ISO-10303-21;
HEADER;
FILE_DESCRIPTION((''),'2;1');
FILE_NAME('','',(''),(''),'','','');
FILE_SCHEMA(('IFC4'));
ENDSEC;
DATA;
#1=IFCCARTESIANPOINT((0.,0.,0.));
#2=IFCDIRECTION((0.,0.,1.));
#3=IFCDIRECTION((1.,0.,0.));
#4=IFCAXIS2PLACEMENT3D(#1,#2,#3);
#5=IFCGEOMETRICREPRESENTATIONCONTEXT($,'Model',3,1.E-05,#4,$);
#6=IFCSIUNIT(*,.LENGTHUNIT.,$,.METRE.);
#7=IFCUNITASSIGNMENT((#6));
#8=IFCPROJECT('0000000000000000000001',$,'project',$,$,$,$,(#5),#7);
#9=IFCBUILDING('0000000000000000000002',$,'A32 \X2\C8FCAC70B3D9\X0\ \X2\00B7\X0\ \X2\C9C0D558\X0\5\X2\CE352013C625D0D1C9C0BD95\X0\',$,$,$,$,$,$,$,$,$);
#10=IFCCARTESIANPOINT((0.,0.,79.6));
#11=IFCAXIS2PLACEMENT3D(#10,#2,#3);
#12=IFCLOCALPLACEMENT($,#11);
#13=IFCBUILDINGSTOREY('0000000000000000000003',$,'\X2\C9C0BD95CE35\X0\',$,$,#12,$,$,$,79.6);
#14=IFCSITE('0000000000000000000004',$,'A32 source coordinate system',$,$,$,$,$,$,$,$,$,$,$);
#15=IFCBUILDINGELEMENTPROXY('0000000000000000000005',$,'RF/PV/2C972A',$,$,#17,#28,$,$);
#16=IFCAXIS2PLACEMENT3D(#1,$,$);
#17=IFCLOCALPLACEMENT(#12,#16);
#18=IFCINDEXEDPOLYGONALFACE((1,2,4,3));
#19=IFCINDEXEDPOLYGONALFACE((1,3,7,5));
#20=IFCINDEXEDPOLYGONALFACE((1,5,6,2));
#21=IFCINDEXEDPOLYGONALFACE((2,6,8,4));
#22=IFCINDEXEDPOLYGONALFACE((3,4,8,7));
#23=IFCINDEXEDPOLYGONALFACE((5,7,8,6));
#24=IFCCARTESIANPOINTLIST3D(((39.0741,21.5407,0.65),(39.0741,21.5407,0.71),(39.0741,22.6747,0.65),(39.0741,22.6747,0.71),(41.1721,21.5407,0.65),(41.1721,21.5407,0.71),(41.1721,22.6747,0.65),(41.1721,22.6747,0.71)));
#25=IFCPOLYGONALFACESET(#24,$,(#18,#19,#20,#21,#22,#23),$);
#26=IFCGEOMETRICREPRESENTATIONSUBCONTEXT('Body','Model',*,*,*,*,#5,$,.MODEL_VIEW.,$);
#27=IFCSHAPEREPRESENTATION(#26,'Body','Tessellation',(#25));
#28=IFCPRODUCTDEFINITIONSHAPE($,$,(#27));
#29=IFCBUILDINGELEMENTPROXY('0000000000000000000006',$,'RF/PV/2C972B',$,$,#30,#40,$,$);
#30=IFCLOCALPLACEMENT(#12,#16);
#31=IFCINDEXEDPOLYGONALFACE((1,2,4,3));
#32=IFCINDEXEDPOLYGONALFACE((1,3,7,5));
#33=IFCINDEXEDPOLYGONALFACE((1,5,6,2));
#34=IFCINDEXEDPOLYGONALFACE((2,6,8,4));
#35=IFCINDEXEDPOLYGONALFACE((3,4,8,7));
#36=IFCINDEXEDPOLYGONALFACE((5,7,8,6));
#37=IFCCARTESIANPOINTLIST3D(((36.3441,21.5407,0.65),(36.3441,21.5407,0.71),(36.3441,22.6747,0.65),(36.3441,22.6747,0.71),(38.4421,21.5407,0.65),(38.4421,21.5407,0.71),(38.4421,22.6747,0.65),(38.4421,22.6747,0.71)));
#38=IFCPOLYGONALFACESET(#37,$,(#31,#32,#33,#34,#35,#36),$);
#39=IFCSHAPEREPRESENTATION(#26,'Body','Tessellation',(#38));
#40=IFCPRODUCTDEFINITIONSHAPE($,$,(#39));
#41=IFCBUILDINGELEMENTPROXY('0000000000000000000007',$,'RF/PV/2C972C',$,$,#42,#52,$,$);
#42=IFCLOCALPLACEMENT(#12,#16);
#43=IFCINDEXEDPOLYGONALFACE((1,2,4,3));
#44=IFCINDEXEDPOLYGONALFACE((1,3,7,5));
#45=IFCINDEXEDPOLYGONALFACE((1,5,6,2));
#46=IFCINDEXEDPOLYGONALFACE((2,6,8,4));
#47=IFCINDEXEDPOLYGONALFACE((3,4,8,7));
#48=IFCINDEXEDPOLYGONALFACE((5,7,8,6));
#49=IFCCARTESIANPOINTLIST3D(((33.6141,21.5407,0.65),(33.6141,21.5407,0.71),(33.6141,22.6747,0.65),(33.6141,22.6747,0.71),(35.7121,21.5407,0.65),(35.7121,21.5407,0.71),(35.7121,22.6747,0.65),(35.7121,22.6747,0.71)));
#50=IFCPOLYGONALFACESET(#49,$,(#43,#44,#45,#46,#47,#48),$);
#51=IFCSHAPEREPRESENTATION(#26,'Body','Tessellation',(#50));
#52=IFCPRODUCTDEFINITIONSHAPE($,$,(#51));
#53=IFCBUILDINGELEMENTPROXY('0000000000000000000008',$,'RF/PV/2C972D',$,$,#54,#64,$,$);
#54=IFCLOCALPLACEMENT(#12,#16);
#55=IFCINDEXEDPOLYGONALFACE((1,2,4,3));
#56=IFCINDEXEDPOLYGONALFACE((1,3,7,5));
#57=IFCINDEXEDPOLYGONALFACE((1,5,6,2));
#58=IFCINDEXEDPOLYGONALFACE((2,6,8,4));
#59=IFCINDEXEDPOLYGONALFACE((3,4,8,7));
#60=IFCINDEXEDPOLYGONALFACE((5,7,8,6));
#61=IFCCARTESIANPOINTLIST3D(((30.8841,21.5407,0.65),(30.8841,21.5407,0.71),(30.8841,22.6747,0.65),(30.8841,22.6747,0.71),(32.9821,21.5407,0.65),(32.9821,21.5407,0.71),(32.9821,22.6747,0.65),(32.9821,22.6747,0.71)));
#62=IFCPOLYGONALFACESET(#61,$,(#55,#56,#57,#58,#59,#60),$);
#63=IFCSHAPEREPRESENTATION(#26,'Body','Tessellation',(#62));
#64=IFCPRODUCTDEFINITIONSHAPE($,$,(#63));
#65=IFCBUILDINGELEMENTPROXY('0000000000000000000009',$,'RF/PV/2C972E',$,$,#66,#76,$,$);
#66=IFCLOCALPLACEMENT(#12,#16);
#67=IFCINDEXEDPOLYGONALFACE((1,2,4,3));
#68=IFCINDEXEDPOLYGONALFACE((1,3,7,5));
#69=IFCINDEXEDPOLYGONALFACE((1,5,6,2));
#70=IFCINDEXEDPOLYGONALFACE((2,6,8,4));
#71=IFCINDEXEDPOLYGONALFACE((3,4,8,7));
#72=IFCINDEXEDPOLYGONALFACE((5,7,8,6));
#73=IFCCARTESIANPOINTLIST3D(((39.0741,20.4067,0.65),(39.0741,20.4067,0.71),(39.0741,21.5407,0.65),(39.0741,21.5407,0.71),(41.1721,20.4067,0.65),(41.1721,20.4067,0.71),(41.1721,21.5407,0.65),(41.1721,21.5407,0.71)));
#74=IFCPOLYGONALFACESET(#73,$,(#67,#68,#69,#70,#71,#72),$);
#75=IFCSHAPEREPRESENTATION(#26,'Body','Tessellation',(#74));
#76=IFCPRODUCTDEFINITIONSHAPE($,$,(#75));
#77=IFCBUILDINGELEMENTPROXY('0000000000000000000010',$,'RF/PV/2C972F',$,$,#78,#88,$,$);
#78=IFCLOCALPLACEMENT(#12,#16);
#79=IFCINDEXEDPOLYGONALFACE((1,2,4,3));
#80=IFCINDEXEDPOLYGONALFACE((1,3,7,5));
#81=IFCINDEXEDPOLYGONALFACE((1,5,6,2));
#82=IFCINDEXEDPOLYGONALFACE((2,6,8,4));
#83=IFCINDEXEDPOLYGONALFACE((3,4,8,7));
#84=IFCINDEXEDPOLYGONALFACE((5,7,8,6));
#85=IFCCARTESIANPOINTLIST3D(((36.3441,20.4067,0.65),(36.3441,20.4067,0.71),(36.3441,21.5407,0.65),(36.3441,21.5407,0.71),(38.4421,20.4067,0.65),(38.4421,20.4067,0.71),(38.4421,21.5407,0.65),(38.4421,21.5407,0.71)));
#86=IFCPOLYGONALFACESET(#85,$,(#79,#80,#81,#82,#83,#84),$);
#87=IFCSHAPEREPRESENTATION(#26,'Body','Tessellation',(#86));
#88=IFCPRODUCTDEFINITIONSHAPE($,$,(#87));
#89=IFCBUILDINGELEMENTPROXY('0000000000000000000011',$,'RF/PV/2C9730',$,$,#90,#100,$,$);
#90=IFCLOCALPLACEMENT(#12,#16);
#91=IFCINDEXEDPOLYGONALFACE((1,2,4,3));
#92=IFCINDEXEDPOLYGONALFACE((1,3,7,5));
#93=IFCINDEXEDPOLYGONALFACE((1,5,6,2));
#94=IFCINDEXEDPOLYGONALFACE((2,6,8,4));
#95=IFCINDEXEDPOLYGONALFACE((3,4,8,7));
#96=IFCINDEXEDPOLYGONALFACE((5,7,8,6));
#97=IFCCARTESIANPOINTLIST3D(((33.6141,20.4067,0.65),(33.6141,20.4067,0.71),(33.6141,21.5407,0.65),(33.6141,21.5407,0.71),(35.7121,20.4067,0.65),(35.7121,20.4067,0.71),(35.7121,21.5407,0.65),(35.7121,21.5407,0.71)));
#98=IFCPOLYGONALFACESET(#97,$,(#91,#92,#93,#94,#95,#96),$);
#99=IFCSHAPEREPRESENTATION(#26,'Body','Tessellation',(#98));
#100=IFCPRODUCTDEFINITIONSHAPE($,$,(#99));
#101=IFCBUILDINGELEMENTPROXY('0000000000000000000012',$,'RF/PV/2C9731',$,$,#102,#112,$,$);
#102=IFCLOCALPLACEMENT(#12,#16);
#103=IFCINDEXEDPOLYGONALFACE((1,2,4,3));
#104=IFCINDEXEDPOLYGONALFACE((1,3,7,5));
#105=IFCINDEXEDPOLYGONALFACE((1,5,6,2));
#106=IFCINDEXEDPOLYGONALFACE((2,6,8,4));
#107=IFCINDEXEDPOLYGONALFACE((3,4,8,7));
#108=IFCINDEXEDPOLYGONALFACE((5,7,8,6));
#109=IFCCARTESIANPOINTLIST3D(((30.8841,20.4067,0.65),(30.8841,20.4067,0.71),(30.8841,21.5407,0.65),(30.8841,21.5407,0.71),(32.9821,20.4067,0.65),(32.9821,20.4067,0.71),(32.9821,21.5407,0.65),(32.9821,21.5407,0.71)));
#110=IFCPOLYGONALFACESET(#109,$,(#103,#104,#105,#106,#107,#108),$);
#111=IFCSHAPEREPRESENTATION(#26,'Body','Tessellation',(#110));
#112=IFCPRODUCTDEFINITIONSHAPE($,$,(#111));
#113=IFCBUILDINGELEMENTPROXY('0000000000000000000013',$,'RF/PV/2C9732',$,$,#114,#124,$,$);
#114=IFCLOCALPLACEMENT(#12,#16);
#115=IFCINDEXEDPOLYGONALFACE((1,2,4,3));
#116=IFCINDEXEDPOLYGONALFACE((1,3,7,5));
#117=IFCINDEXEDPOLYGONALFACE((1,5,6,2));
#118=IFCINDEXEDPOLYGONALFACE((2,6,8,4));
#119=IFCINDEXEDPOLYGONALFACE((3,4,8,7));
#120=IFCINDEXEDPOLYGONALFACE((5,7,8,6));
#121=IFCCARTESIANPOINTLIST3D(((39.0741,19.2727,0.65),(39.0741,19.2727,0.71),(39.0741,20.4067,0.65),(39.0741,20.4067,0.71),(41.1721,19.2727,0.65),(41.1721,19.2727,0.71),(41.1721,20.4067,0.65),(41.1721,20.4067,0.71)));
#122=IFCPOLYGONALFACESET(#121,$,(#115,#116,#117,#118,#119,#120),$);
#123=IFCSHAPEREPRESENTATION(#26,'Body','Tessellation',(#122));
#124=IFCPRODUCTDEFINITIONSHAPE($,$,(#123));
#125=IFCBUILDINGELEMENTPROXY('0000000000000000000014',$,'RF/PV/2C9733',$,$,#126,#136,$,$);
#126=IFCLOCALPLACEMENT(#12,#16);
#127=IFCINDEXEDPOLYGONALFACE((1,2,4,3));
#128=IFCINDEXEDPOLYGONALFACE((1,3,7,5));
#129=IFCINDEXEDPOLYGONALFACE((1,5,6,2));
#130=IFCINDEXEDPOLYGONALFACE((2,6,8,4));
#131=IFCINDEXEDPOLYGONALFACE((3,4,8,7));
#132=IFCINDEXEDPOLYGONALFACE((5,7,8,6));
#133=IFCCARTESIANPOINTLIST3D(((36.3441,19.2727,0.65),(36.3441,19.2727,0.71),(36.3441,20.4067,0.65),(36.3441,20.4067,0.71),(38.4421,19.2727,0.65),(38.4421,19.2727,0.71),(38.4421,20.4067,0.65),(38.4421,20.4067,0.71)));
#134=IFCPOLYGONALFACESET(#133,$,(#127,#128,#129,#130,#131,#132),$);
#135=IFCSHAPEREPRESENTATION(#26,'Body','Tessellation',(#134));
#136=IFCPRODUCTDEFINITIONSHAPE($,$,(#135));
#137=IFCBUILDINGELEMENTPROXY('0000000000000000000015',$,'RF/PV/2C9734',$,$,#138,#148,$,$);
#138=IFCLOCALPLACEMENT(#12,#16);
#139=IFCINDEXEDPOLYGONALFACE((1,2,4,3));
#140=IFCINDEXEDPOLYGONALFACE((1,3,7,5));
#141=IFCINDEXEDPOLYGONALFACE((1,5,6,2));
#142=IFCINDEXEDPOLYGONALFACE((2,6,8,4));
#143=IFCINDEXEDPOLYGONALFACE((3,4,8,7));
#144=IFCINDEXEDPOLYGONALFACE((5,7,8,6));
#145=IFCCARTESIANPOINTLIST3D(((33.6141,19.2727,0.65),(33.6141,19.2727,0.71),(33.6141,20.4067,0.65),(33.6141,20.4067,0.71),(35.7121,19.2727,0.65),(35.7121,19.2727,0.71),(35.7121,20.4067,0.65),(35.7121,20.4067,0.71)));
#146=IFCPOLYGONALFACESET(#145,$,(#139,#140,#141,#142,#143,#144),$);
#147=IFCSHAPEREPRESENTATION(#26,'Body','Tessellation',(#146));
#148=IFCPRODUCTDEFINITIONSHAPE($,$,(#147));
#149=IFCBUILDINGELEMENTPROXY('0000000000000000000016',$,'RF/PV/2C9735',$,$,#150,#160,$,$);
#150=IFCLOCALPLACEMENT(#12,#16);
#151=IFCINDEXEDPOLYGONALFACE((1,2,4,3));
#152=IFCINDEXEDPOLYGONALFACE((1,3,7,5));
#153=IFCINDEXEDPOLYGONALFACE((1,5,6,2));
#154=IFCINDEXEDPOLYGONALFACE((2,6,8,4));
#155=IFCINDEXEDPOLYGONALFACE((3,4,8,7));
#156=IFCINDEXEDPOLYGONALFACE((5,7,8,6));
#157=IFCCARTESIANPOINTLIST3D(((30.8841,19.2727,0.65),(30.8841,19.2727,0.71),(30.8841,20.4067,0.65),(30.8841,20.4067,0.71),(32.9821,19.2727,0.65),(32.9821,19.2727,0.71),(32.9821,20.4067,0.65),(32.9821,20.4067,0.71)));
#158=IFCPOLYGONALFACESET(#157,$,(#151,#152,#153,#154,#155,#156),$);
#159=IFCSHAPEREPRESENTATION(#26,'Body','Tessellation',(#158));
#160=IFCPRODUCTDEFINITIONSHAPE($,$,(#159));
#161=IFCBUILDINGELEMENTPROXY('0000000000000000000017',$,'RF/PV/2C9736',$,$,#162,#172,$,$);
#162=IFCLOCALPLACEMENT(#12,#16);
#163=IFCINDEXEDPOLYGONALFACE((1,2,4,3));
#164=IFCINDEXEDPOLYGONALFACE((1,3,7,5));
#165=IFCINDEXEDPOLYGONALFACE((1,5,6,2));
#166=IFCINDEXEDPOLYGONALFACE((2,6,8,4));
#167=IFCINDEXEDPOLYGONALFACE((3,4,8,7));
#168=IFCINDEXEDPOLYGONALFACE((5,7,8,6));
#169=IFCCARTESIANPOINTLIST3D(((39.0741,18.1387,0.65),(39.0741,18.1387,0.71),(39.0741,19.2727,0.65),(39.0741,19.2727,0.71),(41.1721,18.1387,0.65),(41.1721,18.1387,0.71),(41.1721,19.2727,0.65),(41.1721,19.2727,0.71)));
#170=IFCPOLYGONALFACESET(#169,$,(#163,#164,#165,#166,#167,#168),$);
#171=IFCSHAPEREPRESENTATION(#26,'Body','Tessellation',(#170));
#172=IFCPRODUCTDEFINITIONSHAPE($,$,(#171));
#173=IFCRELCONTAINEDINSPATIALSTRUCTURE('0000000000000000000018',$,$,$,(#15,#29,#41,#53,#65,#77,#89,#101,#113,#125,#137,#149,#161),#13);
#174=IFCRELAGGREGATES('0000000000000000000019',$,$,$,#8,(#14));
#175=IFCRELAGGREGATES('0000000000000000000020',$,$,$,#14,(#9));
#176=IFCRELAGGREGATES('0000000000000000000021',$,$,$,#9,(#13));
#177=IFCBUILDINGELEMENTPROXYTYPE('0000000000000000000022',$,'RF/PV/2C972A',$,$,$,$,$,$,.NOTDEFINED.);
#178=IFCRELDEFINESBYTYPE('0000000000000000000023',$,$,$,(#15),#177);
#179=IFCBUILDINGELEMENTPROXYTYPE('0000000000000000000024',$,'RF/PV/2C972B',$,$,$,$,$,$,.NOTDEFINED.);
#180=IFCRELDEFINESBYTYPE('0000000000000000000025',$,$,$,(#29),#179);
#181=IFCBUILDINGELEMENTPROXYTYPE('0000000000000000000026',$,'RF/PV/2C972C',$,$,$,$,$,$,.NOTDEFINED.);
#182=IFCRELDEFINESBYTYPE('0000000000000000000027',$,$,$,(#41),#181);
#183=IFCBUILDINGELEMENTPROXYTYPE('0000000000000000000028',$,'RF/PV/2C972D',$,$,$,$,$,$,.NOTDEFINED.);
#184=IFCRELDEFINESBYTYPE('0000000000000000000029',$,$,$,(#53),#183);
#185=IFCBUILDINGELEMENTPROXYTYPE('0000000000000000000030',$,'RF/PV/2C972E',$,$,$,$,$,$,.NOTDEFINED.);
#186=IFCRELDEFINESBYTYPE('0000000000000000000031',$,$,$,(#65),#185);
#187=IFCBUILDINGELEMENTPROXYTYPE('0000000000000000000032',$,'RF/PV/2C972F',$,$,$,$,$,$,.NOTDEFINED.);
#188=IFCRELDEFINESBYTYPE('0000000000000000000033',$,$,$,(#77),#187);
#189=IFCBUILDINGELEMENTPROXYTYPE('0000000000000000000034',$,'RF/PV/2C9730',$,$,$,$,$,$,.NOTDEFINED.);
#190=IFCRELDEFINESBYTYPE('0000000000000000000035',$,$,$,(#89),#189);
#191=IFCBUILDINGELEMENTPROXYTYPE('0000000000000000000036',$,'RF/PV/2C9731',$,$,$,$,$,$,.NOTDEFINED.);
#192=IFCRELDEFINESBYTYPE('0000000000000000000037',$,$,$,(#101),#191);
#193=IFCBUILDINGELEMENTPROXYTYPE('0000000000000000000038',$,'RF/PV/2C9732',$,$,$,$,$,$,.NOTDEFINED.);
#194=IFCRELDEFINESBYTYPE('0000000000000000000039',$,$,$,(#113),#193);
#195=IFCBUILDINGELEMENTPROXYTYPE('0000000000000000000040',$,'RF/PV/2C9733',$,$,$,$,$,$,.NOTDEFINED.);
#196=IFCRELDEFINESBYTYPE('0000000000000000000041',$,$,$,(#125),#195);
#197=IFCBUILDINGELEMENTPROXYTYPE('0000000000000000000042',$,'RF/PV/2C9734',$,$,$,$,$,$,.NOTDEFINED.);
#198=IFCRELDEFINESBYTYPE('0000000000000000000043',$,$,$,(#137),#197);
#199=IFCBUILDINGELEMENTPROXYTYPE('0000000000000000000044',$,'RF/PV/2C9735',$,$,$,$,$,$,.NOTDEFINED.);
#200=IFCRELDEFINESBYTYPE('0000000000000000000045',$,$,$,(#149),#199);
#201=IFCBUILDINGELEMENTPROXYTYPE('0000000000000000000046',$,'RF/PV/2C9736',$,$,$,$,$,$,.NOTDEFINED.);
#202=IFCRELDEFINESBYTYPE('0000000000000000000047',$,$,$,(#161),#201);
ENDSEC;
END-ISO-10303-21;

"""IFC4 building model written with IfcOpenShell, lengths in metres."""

from ifc_helpers import new_model, si_unit, frame, origin, origin_with_axes, place, context, subcontext, project, spatial, polyline, outline, extrude, source, transform, mapped, type_object, type_shapes, element, save


model = new_model("IFC4")

# Units and contexts
model_context = context("Model", 3, precision=1e-05, world=origin_with_axes())
body_context = subcontext(model_context, "Body", "Model", "MODEL_VIEW")
ifc_project = project(units=[si_unit("LENGTHUNIT", "METRE")], contexts=[model_context])

# Site, building, storey
site = spatial("IfcSite", under=ifc_project, Name="A32 source coordinate system")
building = spatial("IfcBuilding", under=site, Name="A32 주거동 · 지하5층–옥탑지붕")
storey_placement = place(None, frame((0.0, 0.0, 79.6), z_axis=(0.0, 0.0, 1.0), x_axis=(1.0, 0.0, 0.0)))
storey = spatial("IfcBuildingStorey", under=building, at=storey_placement, Name="지붕층", Elevation=79.6)

# Building element proxies
building_element_proxy_type_1 = type_object("IfcBuildingElementProxyType", Name="RF/PV/2C972A", PredefinedType="NOTDEFINED")
shared_shape_1 = source(origin(), body_context, "Body", "SweptSolid", [
    extrude(outline(polyline([(41.1721, 22.6747), (41.1721, 21.5407), (39.0741, 21.5407), (39.0741, 22.6747), (41.1721, 22.6747)])), frame((0.0, 0.0, 0.65)), (0.0, 0.0, 1.0), 0.06),
])
type_shapes(building_element_proxy_type_1, [shared_shape_1])
proxy_1_placement = place(storey_placement, origin_with_axes())
element("IfcBuildingElementProxy", 1, at=proxy_1_placement, inside=storey, type_object=building_element_proxy_type_1, Name="RF/PV/2C972A", context=body_context, shape_type="MappedRepresentation", body=[
    mapped(shared_shape_1, transform((0.0, 0.0, 0.0), scale=1.0)),
])
building_element_proxy_type_2 = type_object("IfcBuildingElementProxyType", Name="RF/PV/2C972B", PredefinedType="NOTDEFINED")
shared_shape_2 = source(origin(), body_context, "Body", "SweptSolid", [
    extrude(outline(polyline([(38.4421, 22.6747), (38.4421, 21.5407), (36.3441, 21.5407), (36.3441, 22.6747), (38.4421, 22.6747)])), frame((0.0, 0.0, 0.65)), (0.0, 0.0, 1.0), 0.06),
])
type_shapes(building_element_proxy_type_2, [shared_shape_2])
proxy_2_placement = place(storey_placement, origin_with_axes())
element("IfcBuildingElementProxy", 2, at=proxy_2_placement, inside=storey, type_object=building_element_proxy_type_2, Name="RF/PV/2C972B", context=body_context, shape_type="MappedRepresentation", body=[
    mapped(shared_shape_2, transform((0.0, 0.0, 0.0), scale=1.0)),
])
building_element_proxy_type_3 = type_object("IfcBuildingElementProxyType", Name="RF/PV/2C972C", PredefinedType="NOTDEFINED")
shared_shape_3 = source(origin(), body_context, "Body", "SweptSolid", [
    extrude(outline(polyline([(35.7121, 22.6747), (35.7121, 21.5407), (33.6141, 21.5407), (33.6141, 22.6747), (35.7121, 22.6747)])), frame((0.0, 0.0, 0.65)), (0.0, 0.0, 1.0), 0.06),
])
type_shapes(building_element_proxy_type_3, [shared_shape_3])
proxy_3_placement = place(storey_placement, origin_with_axes())
element("IfcBuildingElementProxy", 3, at=proxy_3_placement, inside=storey, type_object=building_element_proxy_type_3, Name="RF/PV/2C972C", context=body_context, shape_type="MappedRepresentation", body=[
    mapped(shared_shape_3, transform((0.0, 0.0, 0.0), scale=1.0)),
])
building_element_proxy_type_4 = type_object("IfcBuildingElementProxyType", Name="RF/PV/2C972D", PredefinedType="NOTDEFINED")
shared_shape_4 = source(origin(), body_context, "Body", "SweptSolid", [
    extrude(outline(polyline([(32.9821, 22.6747), (32.9821, 21.5407), (30.8841, 21.5407), (30.8841, 22.6747), (32.9821, 22.6747)])), frame((0.0, 0.0, 0.65)), (0.0, 0.0, 1.0), 0.06),
])
type_shapes(building_element_proxy_type_4, [shared_shape_4])
proxy_4_placement = place(storey_placement, origin_with_axes())
element("IfcBuildingElementProxy", 4, at=proxy_4_placement, inside=storey, type_object=building_element_proxy_type_4, Name="RF/PV/2C972D", context=body_context, shape_type="MappedRepresentation", body=[
    mapped(shared_shape_4, transform((0.0, 0.0, 0.0), scale=1.0)),
])
building_element_proxy_type_5 = type_object("IfcBuildingElementProxyType", Name="RF/PV/2C972E", PredefinedType="NOTDEFINED")
shared_shape_5 = source(origin(), body_context, "Body", "SweptSolid", [
    extrude(outline(polyline([(41.1721, 21.5407), (41.1721, 20.4067), (39.0741, 20.4067), (39.0741, 21.5407), (41.1721, 21.5407)])), frame((0.0, 0.0, 0.65)), (0.0, 0.0, 1.0), 0.06),
])
type_shapes(building_element_proxy_type_5, [shared_shape_5])
proxy_5_placement = place(storey_placement, origin_with_axes())
element("IfcBuildingElementProxy", 5, at=proxy_5_placement, inside=storey, type_object=building_element_proxy_type_5, Name="RF/PV/2C972E", context=body_context, shape_type="MappedRepresentation", body=[
    mapped(shared_shape_5, transform((0.0, 0.0, 0.0), scale=1.0)),
])
building_element_proxy_type_6 = type_object("IfcBuildingElementProxyType", Name="RF/PV/2C972F", PredefinedType="NOTDEFINED")
shared_shape_6 = source(origin(), body_context, "Body", "SweptSolid", [
    extrude(outline(polyline([(38.4421, 21.5407), (38.4421, 20.4067), (36.3441, 20.4067), (36.3441, 21.5407), (38.4421, 21.5407)])), frame((0.0, 0.0, 0.65)), (0.0, 0.0, 1.0), 0.06),
])
type_shapes(building_element_proxy_type_6, [shared_shape_6])
proxy_6_placement = place(storey_placement, origin_with_axes())
element("IfcBuildingElementProxy", 6, at=proxy_6_placement, inside=storey, type_object=building_element_proxy_type_6, Name="RF/PV/2C972F", context=body_context, shape_type="MappedRepresentation", body=[
    mapped(shared_shape_6, transform((0.0, 0.0, 0.0), scale=1.0)),
])
building_element_proxy_type_7 = type_object("IfcBuildingElementProxyType", Name="RF/PV/2C9730", PredefinedType="NOTDEFINED")
shared_shape_7 = source(origin(), body_context, "Body", "SweptSolid", [
    extrude(outline(polyline([(35.7121, 21.5407), (35.7121, 20.4067), (33.6141, 20.4067), (33.6141, 21.5407), (35.7121, 21.5407)])), frame((0.0, 0.0, 0.65)), (0.0, 0.0, 1.0), 0.06),
])
type_shapes(building_element_proxy_type_7, [shared_shape_7])
proxy_7_placement = place(storey_placement, origin_with_axes())
element("IfcBuildingElementProxy", 7, at=proxy_7_placement, inside=storey, type_object=building_element_proxy_type_7, Name="RF/PV/2C9730", context=body_context, shape_type="MappedRepresentation", body=[
    mapped(shared_shape_7, transform((0.0, 0.0, 0.0), scale=1.0)),
])
building_element_proxy_type_8 = type_object("IfcBuildingElementProxyType", Name="RF/PV/2C9731", PredefinedType="NOTDEFINED")
shared_shape_8 = source(origin(), body_context, "Body", "SweptSolid", [
    extrude(outline(polyline([(32.9821, 21.5407), (32.9821, 20.4067), (30.8841, 20.4067), (30.8841, 21.5407), (32.9821, 21.5407)])), frame((0.0, 0.0, 0.65)), (0.0, 0.0, 1.0), 0.06),
])
type_shapes(building_element_proxy_type_8, [shared_shape_8])
proxy_8_placement = place(storey_placement, origin_with_axes())
element("IfcBuildingElementProxy", 8, at=proxy_8_placement, inside=storey, type_object=building_element_proxy_type_8, Name="RF/PV/2C9731", context=body_context, shape_type="MappedRepresentation", body=[
    mapped(shared_shape_8, transform((0.0, 0.0, 0.0), scale=1.0)),
])
building_element_proxy_type_9 = type_object("IfcBuildingElementProxyType", Name="RF/PV/2C9732", PredefinedType="NOTDEFINED")
shared_shape_9 = source(origin(), body_context, "Body", "SweptSolid", [
    extrude(outline(polyline([(41.1721, 20.4067), (41.1721, 19.2727), (39.0741, 19.2727), (39.0741, 20.4067), (41.1721, 20.4067)])), frame((0.0, 0.0, 0.65)), (0.0, 0.0, 1.0), 0.06),
])
type_shapes(building_element_proxy_type_9, [shared_shape_9])
proxy_9_placement = place(storey_placement, origin_with_axes())
element("IfcBuildingElementProxy", 9, at=proxy_9_placement, inside=storey, type_object=building_element_proxy_type_9, Name="RF/PV/2C9732", context=body_context, shape_type="MappedRepresentation", body=[
    mapped(shared_shape_9, transform((0.0, 0.0, 0.0), scale=1.0)),
])
building_element_proxy_type_10 = type_object("IfcBuildingElementProxyType", Name="RF/PV/2C9733", PredefinedType="NOTDEFINED")
shared_shape_10 = source(origin(), body_context, "Body", "SweptSolid", [
    extrude(outline(polyline([(38.4421, 20.4067), (38.4421, 19.2727), (36.3441, 19.2727), (36.3441, 20.4067), (38.4421, 20.4067)])), frame((0.0, 0.0, 0.65)), (0.0, 0.0, 1.0), 0.06),
])
type_shapes(building_element_proxy_type_10, [shared_shape_10])
proxy_10_placement = place(storey_placement, origin_with_axes())
element("IfcBuildingElementProxy", 10, at=proxy_10_placement, inside=storey, type_object=building_element_proxy_type_10, Name="RF/PV/2C9733", context=body_context, shape_type="MappedRepresentation", body=[
    mapped(shared_shape_10, transform((0.0, 0.0, 0.0), scale=1.0)),
])
building_element_proxy_type_11 = type_object("IfcBuildingElementProxyType", Name="RF/PV/2C9734", PredefinedType="NOTDEFINED")
shared_shape_11 = source(origin(), body_context, "Body", "SweptSolid", [
    extrude(outline(polyline([(35.7121, 20.4067), (35.7121, 19.2727), (33.6141, 19.2727), (33.6141, 20.4067), (35.7121, 20.4067)])), frame((0.0, 0.0, 0.65)), (0.0, 0.0, 1.0), 0.06),
])
type_shapes(building_element_proxy_type_11, [shared_shape_11])
proxy_11_placement = place(storey_placement, origin_with_axes())
element("IfcBuildingElementProxy", 11, at=proxy_11_placement, inside=storey, type_object=building_element_proxy_type_11, Name="RF/PV/2C9734", context=body_context, shape_type="MappedRepresentation", body=[
    mapped(shared_shape_11, transform((0.0, 0.0, 0.0), scale=1.0)),
])
building_element_proxy_type_12 = type_object("IfcBuildingElementProxyType", Name="RF/PV/2C9735", PredefinedType="NOTDEFINED")
shared_shape_12 = source(origin(), body_context, "Body", "SweptSolid", [
    extrude(outline(polyline([(32.9821, 20.4067), (32.9821, 19.2727), (30.8841, 19.2727), (30.8841, 20.4067), (32.9821, 20.4067)])), frame((0.0, 0.0, 0.65)), (0.0, 0.0, 1.0), 0.06),
])
type_shapes(building_element_proxy_type_12, [shared_shape_12])
proxy_12_placement = place(storey_placement, origin_with_axes())
element("IfcBuildingElementProxy", 12, at=proxy_12_placement, inside=storey, type_object=building_element_proxy_type_12, Name="RF/PV/2C9735", context=body_context, shape_type="MappedRepresentation", body=[
    mapped(shared_shape_12, transform((0.0, 0.0, 0.0), scale=1.0)),
])
building_element_proxy_type_13 = type_object("IfcBuildingElementProxyType", Name="RF/PV/2C9736", PredefinedType="NOTDEFINED")
shared_shape_13 = source(origin(), body_context, "Body", "SweptSolid", [
    extrude(outline(polyline([(41.1721, 19.2727), (41.1721, 18.1387), (39.0741, 18.1387), (39.0741, 19.2727), (41.1721, 19.2727)])), frame((0.0, 0.0, 0.65)), (0.0, 0.0, 1.0), 0.06),
])
type_shapes(building_element_proxy_type_13, [shared_shape_13])
proxy_13_placement = place(storey_placement, origin_with_axes())
element("IfcBuildingElementProxy", 13, at=proxy_13_placement, inside=storey, type_object=building_element_proxy_type_13, Name="RF/PV/2C9736", context=body_context, shape_type="MappedRepresentation", body=[
    mapped(shared_shape_13, transform((0.0, 0.0, 0.0), scale=1.0)),
])

save(model, "model.ifc")
